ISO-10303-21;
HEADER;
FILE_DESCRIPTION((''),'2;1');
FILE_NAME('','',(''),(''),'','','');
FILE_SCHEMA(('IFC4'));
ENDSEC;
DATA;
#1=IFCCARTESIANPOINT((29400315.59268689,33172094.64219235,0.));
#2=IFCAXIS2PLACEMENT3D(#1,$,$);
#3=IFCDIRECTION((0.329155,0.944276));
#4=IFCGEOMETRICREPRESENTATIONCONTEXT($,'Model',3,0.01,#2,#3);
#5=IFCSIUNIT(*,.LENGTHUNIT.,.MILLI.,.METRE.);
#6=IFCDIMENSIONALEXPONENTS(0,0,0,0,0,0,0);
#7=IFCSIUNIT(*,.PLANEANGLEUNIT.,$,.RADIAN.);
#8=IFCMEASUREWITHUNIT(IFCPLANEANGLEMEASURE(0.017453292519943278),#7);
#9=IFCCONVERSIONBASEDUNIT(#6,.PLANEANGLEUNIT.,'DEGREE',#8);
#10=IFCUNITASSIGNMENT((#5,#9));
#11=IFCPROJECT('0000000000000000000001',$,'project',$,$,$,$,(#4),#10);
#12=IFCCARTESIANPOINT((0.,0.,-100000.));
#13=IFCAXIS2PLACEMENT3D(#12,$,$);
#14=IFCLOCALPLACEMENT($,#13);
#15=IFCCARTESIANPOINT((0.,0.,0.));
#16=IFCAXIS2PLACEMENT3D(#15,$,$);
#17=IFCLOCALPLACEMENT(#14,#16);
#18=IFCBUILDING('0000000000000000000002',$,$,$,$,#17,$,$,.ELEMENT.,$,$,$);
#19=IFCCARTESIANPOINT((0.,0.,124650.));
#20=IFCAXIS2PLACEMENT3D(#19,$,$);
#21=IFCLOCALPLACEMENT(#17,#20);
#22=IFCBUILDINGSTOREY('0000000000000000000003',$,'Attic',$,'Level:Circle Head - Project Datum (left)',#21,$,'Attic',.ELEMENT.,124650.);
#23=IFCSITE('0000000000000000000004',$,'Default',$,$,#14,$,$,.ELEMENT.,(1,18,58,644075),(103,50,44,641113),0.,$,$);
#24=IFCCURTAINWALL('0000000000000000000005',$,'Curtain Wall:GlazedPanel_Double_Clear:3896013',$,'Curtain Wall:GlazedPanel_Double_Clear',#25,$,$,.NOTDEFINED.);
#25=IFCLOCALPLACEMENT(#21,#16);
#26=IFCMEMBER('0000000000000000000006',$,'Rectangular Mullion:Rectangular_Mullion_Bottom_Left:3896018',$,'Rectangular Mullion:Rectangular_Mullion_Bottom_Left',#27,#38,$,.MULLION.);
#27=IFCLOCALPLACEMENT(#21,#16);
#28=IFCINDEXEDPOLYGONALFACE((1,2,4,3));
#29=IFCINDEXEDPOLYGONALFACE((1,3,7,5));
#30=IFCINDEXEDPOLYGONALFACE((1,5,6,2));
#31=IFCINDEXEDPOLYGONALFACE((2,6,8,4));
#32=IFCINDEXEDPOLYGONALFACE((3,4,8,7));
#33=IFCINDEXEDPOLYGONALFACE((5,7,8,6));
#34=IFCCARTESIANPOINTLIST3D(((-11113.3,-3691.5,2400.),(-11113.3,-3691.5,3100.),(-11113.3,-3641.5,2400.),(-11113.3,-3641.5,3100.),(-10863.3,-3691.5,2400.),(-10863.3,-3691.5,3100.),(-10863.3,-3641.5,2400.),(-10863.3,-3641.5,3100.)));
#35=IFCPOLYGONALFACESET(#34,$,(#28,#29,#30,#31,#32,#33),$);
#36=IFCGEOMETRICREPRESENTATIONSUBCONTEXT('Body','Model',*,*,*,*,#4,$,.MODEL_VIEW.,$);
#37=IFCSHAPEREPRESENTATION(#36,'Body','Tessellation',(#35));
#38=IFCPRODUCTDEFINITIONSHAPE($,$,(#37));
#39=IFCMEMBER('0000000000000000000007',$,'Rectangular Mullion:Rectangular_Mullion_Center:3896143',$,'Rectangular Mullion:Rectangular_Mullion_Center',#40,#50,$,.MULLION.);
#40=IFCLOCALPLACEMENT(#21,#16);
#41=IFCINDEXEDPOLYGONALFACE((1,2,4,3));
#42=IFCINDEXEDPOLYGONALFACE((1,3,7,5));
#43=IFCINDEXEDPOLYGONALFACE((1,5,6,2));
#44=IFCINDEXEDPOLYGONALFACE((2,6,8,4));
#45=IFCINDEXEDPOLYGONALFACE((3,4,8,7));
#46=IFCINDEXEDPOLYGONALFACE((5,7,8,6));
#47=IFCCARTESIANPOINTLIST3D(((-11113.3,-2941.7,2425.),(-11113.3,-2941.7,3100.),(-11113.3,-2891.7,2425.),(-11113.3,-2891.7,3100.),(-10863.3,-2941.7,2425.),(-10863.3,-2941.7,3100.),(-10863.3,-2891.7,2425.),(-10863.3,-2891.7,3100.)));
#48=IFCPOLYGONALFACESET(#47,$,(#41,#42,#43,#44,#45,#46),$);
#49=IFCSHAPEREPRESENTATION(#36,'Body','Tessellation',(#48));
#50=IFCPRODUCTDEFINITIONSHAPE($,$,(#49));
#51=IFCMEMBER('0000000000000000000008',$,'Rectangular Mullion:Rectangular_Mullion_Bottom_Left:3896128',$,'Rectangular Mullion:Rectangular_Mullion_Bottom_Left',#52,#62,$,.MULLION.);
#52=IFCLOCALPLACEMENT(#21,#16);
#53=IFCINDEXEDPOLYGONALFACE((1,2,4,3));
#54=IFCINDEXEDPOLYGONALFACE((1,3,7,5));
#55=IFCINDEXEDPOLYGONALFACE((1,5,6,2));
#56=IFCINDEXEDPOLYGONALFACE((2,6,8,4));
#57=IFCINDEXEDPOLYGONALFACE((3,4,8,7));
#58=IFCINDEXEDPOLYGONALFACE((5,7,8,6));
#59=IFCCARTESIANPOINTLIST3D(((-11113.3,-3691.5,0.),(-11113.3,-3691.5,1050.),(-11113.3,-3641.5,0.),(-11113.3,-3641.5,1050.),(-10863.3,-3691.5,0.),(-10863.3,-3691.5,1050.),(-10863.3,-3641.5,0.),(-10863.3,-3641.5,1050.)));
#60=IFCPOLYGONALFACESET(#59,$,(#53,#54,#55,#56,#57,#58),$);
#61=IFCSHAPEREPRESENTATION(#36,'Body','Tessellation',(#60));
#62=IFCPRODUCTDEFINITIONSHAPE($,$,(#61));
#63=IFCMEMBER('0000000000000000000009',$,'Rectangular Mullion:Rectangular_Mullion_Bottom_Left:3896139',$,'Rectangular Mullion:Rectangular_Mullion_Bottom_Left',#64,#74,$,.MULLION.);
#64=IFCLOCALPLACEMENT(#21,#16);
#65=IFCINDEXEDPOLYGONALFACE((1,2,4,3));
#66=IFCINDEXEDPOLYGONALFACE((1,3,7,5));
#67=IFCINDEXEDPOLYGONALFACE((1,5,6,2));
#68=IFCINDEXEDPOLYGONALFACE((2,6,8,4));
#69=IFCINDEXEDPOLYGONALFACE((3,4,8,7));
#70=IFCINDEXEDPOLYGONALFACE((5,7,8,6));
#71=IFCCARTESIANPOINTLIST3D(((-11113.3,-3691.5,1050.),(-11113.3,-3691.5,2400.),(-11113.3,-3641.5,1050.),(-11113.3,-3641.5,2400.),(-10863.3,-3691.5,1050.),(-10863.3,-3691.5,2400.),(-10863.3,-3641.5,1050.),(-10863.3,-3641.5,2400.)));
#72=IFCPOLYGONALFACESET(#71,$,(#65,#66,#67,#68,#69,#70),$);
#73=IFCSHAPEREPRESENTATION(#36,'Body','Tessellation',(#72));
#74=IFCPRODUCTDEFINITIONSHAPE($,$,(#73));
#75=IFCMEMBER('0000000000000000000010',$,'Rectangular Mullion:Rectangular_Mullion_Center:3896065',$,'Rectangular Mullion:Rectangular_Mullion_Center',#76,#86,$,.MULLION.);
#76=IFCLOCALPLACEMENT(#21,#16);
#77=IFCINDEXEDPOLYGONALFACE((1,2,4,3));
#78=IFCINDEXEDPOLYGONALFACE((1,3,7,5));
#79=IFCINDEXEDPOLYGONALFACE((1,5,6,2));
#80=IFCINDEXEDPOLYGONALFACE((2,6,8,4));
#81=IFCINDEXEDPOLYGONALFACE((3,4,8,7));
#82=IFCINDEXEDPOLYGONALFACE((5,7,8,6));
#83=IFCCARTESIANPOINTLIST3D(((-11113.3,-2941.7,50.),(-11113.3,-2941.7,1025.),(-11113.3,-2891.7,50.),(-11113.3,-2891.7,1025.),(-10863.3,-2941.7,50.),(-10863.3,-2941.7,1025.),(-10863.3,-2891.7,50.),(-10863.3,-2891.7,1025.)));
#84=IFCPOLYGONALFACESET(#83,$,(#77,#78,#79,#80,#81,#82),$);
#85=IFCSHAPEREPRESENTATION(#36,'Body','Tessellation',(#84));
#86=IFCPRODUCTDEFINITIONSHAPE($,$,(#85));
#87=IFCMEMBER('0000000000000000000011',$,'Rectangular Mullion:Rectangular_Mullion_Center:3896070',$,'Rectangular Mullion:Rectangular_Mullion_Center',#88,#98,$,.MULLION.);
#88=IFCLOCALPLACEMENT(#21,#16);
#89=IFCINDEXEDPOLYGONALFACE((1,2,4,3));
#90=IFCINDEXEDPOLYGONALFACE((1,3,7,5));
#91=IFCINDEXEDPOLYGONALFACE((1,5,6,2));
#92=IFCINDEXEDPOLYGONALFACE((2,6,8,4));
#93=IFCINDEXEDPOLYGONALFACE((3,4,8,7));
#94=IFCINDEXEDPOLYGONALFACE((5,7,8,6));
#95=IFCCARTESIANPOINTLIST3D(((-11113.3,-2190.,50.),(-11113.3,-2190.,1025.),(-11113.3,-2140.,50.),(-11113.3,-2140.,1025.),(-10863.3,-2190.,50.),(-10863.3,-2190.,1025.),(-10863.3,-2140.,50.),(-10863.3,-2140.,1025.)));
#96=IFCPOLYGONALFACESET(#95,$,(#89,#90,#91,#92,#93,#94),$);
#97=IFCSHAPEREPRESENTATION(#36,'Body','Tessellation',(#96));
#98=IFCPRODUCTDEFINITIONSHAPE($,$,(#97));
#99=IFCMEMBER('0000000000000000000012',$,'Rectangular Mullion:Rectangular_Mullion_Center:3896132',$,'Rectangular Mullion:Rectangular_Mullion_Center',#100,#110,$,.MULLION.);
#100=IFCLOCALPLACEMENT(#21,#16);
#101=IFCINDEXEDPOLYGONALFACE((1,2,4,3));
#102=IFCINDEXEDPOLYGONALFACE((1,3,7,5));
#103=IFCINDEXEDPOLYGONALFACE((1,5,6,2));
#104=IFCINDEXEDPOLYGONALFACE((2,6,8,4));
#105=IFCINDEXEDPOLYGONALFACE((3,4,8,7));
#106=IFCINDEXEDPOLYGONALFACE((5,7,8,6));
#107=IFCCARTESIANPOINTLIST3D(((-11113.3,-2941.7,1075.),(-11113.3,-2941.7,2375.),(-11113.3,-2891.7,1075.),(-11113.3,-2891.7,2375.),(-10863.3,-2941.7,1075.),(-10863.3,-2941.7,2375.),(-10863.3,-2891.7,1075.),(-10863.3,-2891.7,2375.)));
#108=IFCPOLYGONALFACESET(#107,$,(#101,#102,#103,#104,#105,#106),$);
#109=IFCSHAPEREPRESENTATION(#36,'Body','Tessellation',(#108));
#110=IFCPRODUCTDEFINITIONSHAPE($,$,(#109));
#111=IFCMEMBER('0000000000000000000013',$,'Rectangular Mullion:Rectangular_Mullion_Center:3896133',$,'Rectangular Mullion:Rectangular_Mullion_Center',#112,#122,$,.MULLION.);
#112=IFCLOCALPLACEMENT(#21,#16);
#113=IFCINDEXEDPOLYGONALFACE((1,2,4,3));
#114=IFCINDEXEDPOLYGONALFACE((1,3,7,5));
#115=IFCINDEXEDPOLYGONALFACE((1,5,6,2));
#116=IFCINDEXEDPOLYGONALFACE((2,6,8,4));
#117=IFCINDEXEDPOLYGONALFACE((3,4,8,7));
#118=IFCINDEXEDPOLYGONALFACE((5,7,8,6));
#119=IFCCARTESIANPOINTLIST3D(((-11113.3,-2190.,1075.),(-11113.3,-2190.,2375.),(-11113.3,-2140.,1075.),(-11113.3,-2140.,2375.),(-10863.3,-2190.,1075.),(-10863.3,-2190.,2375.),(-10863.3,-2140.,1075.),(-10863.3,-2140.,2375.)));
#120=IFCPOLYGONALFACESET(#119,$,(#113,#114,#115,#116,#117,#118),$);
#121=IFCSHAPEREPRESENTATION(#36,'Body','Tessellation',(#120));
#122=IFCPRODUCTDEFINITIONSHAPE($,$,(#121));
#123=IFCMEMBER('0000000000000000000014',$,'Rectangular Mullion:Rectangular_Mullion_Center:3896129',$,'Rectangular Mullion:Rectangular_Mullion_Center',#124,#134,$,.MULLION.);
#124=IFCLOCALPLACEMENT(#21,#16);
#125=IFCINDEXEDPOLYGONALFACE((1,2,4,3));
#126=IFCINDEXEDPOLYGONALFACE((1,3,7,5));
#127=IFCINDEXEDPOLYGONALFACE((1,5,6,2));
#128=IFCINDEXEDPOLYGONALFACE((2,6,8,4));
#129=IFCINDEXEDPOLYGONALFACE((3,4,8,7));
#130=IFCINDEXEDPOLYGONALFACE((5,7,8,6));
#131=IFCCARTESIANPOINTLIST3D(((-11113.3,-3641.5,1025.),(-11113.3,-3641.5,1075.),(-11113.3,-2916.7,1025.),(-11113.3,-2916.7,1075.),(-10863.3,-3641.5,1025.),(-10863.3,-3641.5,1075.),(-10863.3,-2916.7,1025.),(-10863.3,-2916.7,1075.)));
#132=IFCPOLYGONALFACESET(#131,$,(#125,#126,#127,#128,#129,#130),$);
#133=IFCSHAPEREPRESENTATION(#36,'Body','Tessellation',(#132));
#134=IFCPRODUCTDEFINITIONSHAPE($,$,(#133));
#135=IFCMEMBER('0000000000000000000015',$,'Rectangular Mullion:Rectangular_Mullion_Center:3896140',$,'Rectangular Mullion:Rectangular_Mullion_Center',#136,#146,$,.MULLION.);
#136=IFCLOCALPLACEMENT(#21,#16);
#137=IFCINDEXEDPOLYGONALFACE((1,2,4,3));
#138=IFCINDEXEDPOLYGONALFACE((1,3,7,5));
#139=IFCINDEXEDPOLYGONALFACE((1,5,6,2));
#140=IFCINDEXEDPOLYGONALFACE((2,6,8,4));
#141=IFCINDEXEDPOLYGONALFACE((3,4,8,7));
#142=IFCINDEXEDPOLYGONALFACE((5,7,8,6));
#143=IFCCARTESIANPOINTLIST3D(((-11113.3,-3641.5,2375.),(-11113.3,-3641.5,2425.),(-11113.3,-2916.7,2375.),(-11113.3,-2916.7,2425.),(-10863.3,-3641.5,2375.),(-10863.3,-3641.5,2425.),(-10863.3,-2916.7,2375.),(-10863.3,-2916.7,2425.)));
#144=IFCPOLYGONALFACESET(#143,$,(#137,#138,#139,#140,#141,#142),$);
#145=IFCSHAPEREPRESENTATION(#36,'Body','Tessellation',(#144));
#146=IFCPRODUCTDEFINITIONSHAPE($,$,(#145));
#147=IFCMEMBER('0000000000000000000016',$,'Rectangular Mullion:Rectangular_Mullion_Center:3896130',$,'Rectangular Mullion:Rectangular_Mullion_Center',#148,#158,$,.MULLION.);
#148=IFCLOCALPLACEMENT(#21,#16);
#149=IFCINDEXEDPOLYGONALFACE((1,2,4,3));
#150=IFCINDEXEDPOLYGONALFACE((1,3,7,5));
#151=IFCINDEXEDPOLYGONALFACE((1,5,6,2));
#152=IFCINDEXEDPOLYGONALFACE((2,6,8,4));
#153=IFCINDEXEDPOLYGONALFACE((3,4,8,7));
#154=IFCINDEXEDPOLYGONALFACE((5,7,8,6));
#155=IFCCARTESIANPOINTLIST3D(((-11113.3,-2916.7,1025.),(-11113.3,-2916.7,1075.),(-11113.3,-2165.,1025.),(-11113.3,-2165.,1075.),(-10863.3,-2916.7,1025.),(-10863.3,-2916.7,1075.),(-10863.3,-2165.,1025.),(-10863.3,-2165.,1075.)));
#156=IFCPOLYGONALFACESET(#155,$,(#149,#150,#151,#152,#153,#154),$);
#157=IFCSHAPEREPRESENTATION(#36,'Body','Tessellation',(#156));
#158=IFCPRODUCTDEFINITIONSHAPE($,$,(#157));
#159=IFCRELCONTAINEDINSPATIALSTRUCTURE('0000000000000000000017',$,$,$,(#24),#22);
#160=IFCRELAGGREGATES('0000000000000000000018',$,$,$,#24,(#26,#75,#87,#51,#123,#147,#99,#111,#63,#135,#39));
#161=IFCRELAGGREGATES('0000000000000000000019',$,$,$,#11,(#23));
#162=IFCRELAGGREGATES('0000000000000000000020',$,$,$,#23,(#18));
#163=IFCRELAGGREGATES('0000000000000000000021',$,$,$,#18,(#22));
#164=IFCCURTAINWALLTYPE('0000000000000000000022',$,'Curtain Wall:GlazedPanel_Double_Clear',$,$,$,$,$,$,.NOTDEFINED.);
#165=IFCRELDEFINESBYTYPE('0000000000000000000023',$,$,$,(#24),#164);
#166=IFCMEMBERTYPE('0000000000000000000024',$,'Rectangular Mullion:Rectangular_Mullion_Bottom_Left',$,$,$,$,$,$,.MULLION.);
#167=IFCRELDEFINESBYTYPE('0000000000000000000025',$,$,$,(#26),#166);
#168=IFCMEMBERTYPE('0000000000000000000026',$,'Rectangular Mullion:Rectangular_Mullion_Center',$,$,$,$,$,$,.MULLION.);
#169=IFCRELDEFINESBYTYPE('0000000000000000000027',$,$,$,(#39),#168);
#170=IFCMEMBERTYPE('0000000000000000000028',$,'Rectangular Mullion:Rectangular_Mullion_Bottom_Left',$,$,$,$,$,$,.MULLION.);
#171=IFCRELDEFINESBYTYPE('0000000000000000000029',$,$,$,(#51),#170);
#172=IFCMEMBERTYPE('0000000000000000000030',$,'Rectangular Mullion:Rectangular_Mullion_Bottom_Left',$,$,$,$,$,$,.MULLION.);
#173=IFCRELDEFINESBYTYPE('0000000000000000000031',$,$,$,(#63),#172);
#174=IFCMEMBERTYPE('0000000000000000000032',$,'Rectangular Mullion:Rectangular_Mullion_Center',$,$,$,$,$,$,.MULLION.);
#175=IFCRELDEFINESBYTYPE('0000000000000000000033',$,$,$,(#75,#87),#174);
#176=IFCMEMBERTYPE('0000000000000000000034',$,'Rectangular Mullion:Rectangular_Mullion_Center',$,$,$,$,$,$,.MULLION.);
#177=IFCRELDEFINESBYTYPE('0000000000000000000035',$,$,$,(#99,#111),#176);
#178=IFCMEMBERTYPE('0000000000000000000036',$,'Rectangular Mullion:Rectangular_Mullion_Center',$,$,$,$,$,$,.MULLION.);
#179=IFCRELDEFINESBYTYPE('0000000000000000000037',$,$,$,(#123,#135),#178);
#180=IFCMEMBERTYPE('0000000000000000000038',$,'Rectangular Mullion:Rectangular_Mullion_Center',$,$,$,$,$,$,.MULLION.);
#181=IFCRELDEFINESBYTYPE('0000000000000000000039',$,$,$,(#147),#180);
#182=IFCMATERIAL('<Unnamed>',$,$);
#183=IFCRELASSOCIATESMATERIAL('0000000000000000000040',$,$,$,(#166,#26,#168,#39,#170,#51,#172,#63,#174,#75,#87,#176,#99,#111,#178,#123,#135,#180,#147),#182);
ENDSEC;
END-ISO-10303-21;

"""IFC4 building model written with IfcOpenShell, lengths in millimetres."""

from ifc_helpers import new_model, entity, si_unit, converted_unit, direction, frame, origin, place, context, subcontext, project, spatial, indexed_curve, outline, extrude, source, transform, mapped, material, type_object, type_shapes, element, aggregate, save


model = new_model("IFC4")

# Units and contexts
model_context = context("Model", 3, precision=0.01, world=frame((29400315.59268689, 33172094.64219235, 0.0)), true_north=direction((0.329155, 0.944276)))
body_context = subcontext(model_context, "Body", "Model", "MODEL_VIEW")
ifc_project = project(units=[si_unit("LENGTHUNIT", "METRE", prefix="MILLI"), converted_unit("PLANEANGLEUNIT", "DEGREE", entity("IfcPlaneAngleMeasure", 0.017453292519943278), si_unit("PLANEANGLEUNIT", "RADIAN"), dimensions=[0, 0, 0, 0, 0, 0, 0])], contexts=[model_context])

# Site, building, storey
site_placement = place(None, frame((0.0, 0.0, -100000.0)))
site = spatial("IfcSite", under=ifc_project, at=site_placement, Name="Default", CompositionType="ELEMENT", RefLatitude=(1, 18, 58, 644075), RefLongitude=(103, 50, 44, 641113), RefElevation=0.0)
building_placement = place(site_placement, origin())
building = spatial("IfcBuilding", under=site, at=building_placement, CompositionType="ELEMENT")
storey_placement = place(building_placement, frame((0.0, 0.0, 124650.0)))
storey = spatial("IfcBuildingStorey", under=building, at=storey_placement, Name="Attic", ObjectType="Level:Circle Head - Project Datum (left)", LongName="Attic", CompositionType="ELEMENT", Elevation=124650.0)

# Curtain wall, members
curtain_wall_type = type_object("IfcCurtainWallType", Name="Curtain Wall:GlazedPanel_Double_Clear", PredefinedType="NOTDEFINED")
curtain_wall_1_placement = place(storey_placement, frame((0.0, 0.0, -124650.0)))
curtain_wall_1 = element("IfcCurtainWall", 1, at=curtain_wall_1_placement, inside=storey, type_object=curtain_wall_type, Name="Curtain Wall:GlazedPanel_Double_Clear:3896013", ObjectType="Curtain Wall:GlazedPanel_Double_Clear", PredefinedType="NOTDEFINED")
ifc_material_1 = material(Name="<Unnamed>")
member_type_1 = type_object("IfcMemberType", Name="Rectangular Mullion:Rectangular_Mullion_Bottom_Left", PredefinedType="MULLION", material=ifc_material_1)
shared_shape_1 = source(origin(), body_context, "Body", "SweptSolid", [
    extrude(outline(indexed_curve([(-25.0, -125.0), (25.0, -125.0), (25.0, 125.0), (-25.0, 125.0), (-25.0, -125.0)], self_intersect=False)), frame((-25.0, 0.0, -700.0), z_axis=(0.0, 0.0, 1.0), x_axis=(-1.0, 0.0, 0.0)), (0.0, 0.0, 1.0), 700.0),
])
type_shapes(member_type_1, [shared_shape_1])
member_1_placement = place(curtain_wall_1_placement, frame((-10988.3, -3691.5, 127750.0), z_axis=(0.0, 0.0, 1.0), x_axis=(0.0, -1.0, 0.0)))
member_1 = element("IfcMember", 2, at=member_1_placement, type_object=member_type_1, material=ifc_material_1, Name="Rectangular Mullion:Rectangular_Mullion_Bottom_Left:3896018", ObjectType="Rectangular Mullion:Rectangular_Mullion_Bottom_Left", PredefinedType="MULLION", context=body_context, shape_type="MappedRepresentation", body=[
    mapped(shared_shape_1, transform((0.0, 0.0, 0.0), scale=1.0)),
])
member_type_2 = type_object("IfcMemberType", Name="Rectangular Mullion:Rectangular_Mullion_Center", PredefinedType="MULLION", material=ifc_material_1)
shared_shape_2 = source(origin(), body_context, "Body", "SweptSolid", [
    extrude(outline(indexed_curve([(-25.0, -125.0), (25.0, -125.0), (25.0, 125.0), (-25.0, 125.0), (-25.0, -125.0)], self_intersect=False)), frame((0.0, 0.0, -675.0), z_axis=(0.0, 0.0, 1.0), x_axis=(-1.0, 0.0, 0.0)), (0.0, 0.0, 1.0), 675.0),
])
type_shapes(member_type_2, [shared_shape_2])
member_2_placement = place(curtain_wall_1_placement, frame((-10988.3, -2916.7, 127075.0), z_axis=(0.0, 0.0, -1.0), x_axis=(0.0, 1.0, 0.0)))
member_2 = element("IfcMember", 3, at=member_2_placement, type_object=member_type_2, material=ifc_material_1, Name="Rectangular Mullion:Rectangular_Mullion_Center:3896143", ObjectType="Rectangular Mullion:Rectangular_Mullion_Center", PredefinedType="MULLION", context=body_context, shape_type="MappedRepresentation", body=[
    mapped(shared_shape_2, transform((0.0, 0.0, 0.0), scale=1.0)),
])
member_type_3 = type_object("IfcMemberType", Name="Rectangular Mullion:Rectangular_Mullion_Bottom_Left", PredefinedType="MULLION", material=ifc_material_1)
shared_shape_3 = source(origin(), body_context, "Body", "SweptSolid", [
    extrude(outline(indexed_curve([(-25.0, -125.0), (25.0, -125.0), (25.0, 125.0), (-25.0, 125.0), (-25.0, -125.0)], self_intersect=False)), frame((-25.0, 0.0, -1050.0), z_axis=(0.0, 0.0, 1.0), x_axis=(-1.0, 0.0, 0.0)), (0.0, 0.0, 1.0), 1050.0),
])
type_shapes(member_type_3, [shared_shape_3])
member_3_placement = place(curtain_wall_1_placement, frame((-10988.3, -3691.5, 125700.0), z_axis=(0.0, 0.0, 1.0), x_axis=(0.0, -1.0, 0.0)))
member_3 = element("IfcMember", 4, at=member_3_placement, type_object=member_type_3, material=ifc_material_1, Name="Rectangular Mullion:Rectangular_Mullion_Bottom_Left:3896128", ObjectType="Rectangular Mullion:Rectangular_Mullion_Bottom_Left", PredefinedType="MULLION", context=body_context, shape_type="MappedRepresentation", body=[
    mapped(shared_shape_3, transform((0.0, 0.0, 0.0), scale=1.0)),
])
member_type_4 = type_object("IfcMemberType", Name="Rectangular Mullion:Rectangular_Mullion_Bottom_Left", PredefinedType="MULLION", material=ifc_material_1)
shared_shape_4 = source(origin(), body_context, "Body", "SweptSolid", [
    extrude(outline(indexed_curve([(-25.0, -125.0), (25.0, -125.0), (25.0, 125.0), (-25.0, 125.0), (-25.0, -125.0)], self_intersect=False)), frame((-25.0, 0.0, -1350.0), z_axis=(0.0, 0.0, 1.0), x_axis=(-1.0, 0.0, 0.0)), (0.0, 0.0, 1.0), 1350.0),
])
type_shapes(member_type_4, [shared_shape_4])
member_4_placement = place(curtain_wall_1_placement, frame((-10988.3, -3691.5, 127050.0), z_axis=(0.0, 0.0, 1.0), x_axis=(0.0, -1.0, 0.0)))
member_4 = element("IfcMember", 5, at=member_4_placement, type_object=member_type_4, material=ifc_material_1, Name="Rectangular Mullion:Rectangular_Mullion_Bottom_Left:3896139", ObjectType="Rectangular Mullion:Rectangular_Mullion_Bottom_Left", PredefinedType="MULLION", context=body_context, shape_type="MappedRepresentation", body=[
    mapped(shared_shape_4, transform((0.0, 0.0, 0.0), scale=1.0)),
])
member_type_5 = type_object("IfcMemberType", Name="Rectangular Mullion:Rectangular_Mullion_Center", PredefinedType="MULLION", material=ifc_material_1)
shared_shape_5 = source(origin(), body_context, "Body", "SweptSolid", [
    extrude(outline(indexed_curve([(-25.0, -125.0), (25.0, -125.0), (25.0, 125.0), (-25.0, 125.0), (-25.0, -125.0)], self_intersect=False)), frame((0.0, 0.0, -975.0), z_axis=(0.0, 0.0, 1.0), x_axis=(-1.0, 0.0, 0.0)), (0.0, 0.0, 1.0), 975.0),
])
type_shapes(member_type_5, [shared_shape_5])
member_5_placement = place(curtain_wall_1_placement, frame((-10988.3, -2916.7, 124700.0), z_axis=(0.0, 0.0, -1.0), x_axis=(0.0, 1.0, 0.0)))
member_5 = element("IfcMember", 6, at=member_5_placement, type_object=member_type_5, material=ifc_material_1, Name="Rectangular Mullion:Rectangular_Mullion_Center:3896065", ObjectType="Rectangular Mullion:Rectangular_Mullion_Center", PredefinedType="MULLION", context=body_context, shape_type="MappedRepresentation", body=[
    mapped(shared_shape_5, transform((0.0, 0.0, 0.0), scale=1.0)),
])
member_6_placement = place(curtain_wall_1_placement, frame((-10988.3, -2165.0, 124700.0), z_axis=(0.0, 0.0, -1.0), x_axis=(0.0, 1.0, 0.0)))
member_6 = element("IfcMember", 7, at=member_6_placement, type_object=member_type_5, material=ifc_material_1, Name="Rectangular Mullion:Rectangular_Mullion_Center:3896070", ObjectType="Rectangular Mullion:Rectangular_Mullion_Center", PredefinedType="MULLION", context=body_context, shape_type="MappedRepresentation", body=[
    mapped(shared_shape_5, transform((0.0, 0.0, 0.0), scale=1.0)),
])
member_type_6 = type_object("IfcMemberType", Name="Rectangular Mullion:Rectangular_Mullion_Center", PredefinedType="MULLION", material=ifc_material_1)
shared_shape_6 = source(origin(), body_context, "Body", "SweptSolid", [
    extrude(outline(indexed_curve([(-25.0, -125.0), (25.0, -125.0), (25.0, 125.0), (-25.0, 125.0), (-25.0, -125.0)], self_intersect=False)), frame((0.0, 0.0, -1300.0), z_axis=(0.0, 0.0, 1.0), x_axis=(-1.0, 0.0, 0.0)), (0.0, 0.0, 1.0), 1300.0),
])
type_shapes(member_type_6, [shared_shape_6])
member_7_placement = place(curtain_wall_1_placement, frame((-10988.3, -2916.7, 125725.0), z_axis=(0.0, 0.0, -1.0), x_axis=(0.0, 1.0, 0.0)))
member_7 = element("IfcMember", 8, at=member_7_placement, type_object=member_type_6, material=ifc_material_1, Name="Rectangular Mullion:Rectangular_Mullion_Center:3896132", ObjectType="Rectangular Mullion:Rectangular_Mullion_Center", PredefinedType="MULLION", context=body_context, shape_type="MappedRepresentation", body=[
    mapped(shared_shape_6, transform((0.0, 0.0, 0.0), scale=1.0)),
])
member_8_placement = place(curtain_wall_1_placement, frame((-10988.3, -2165.0, 125725.0), z_axis=(0.0, 0.0, -1.0), x_axis=(0.0, 1.0, 0.0)))
member_8 = element("IfcMember", 9, at=member_8_placement, type_object=member_type_6, material=ifc_material_1, Name="Rectangular Mullion:Rectangular_Mullion_Center:3896133", ObjectType="Rectangular Mullion:Rectangular_Mullion_Center", PredefinedType="MULLION", context=body_context, shape_type="MappedRepresentation", body=[
    mapped(shared_shape_6, transform((0.0, 0.0, 0.0), scale=1.0)),
])
member_type_7 = type_object("IfcMemberType", Name="Rectangular Mullion:Rectangular_Mullion_Center", PredefinedType="MULLION", material=ifc_material_1)
shared_shape_7 = source(origin(), body_context, "Body", "SweptSolid", [
    extrude(outline(indexed_curve([(-25.0, -125.0), (25.0, -125.0), (25.0, 125.0), (-25.0, 125.0), (-25.0, -125.0)], self_intersect=False)), frame((0.0, 0.0, -724.8), z_axis=(0.0, 0.0, 1.0), x_axis=(-1.0, 0.0, 0.0)), (0.0, 0.0, 1.0), 724.8),
])
type_shapes(member_type_7, [shared_shape_7])
member_9_placement = place(curtain_wall_1_placement, frame((-10988.3, -2916.7, 125700.0), z_axis=(0.0, 1.0, 0.0), x_axis=(0.0, 0.0, 1.0)))
member_9 = element("IfcMember", 10, at=member_9_placement, type_object=member_type_7, material=ifc_material_1, Name="Rectangular Mullion:Rectangular_Mullion_Center:3896129", ObjectType="Rectangular Mullion:Rectangular_Mullion_Center", PredefinedType="MULLION", context=body_context, shape_type="MappedRepresentation", body=[
    mapped(shared_shape_7, transform((0.0, 0.0, 0.0), scale=1.0)),
])
member_10_placement = place(curtain_wall_1_placement, frame((-10988.3, -2916.7, 127050.0), z_axis=(0.0, 1.0, 0.0), x_axis=(0.0, 0.0, 1.0)))
member_10 = element("IfcMember", 11, at=member_10_placement, type_object=member_type_7, material=ifc_material_1, Name="Rectangular Mullion:Rectangular_Mullion_Center:3896140", ObjectType="Rectangular Mullion:Rectangular_Mullion_Center", PredefinedType="MULLION", context=body_context, shape_type="MappedRepresentation", body=[
    mapped(shared_shape_7, transform((0.0, 0.0, 0.0), scale=1.0)),
])
member_type_8 = type_object("IfcMemberType", Name="Rectangular Mullion:Rectangular_Mullion_Center", PredefinedType="MULLION", material=ifc_material_1)
shared_shape_8 = source(origin(), body_context, "Body", "SweptSolid", [
    extrude(outline(indexed_curve([(-25.0, -125.0), (25.0, -125.0), (25.0, 125.0), (-25.0, 125.0), (-25.0, -125.0)], self_intersect=False)), frame((0.0, 0.0, -751.7), z_axis=(0.0, 0.0, 1.0), x_axis=(-1.0, 0.0, 0.0)), (0.0, 0.0, 1.0), 751.7),
])
type_shapes(member_type_8, [shared_shape_8])
member_11_placement = place(curtain_wall_1_placement, frame((-10988.3, -2165.0, 125700.0), z_axis=(0.0, 1.0, 0.0), x_axis=(0.0, 0.0, 1.0)))
member_11 = element("IfcMember", 12, at=member_11_placement, type_object=member_type_8, material=ifc_material_1, Name="Rectangular Mullion:Rectangular_Mullion_Center:3896130", ObjectType="Rectangular Mullion:Rectangular_Mullion_Center", PredefinedType="MULLION", context=body_context, shape_type="MappedRepresentation", body=[
    mapped(shared_shape_8, transform((0.0, 0.0, 0.0), scale=1.0)),
])

aggregate(curtain_wall_1, [member_1, member_5, member_6, member_3, member_9, member_11, member_7, member_8, member_4, member_10, member_2])

save(model, "model.ifc")
